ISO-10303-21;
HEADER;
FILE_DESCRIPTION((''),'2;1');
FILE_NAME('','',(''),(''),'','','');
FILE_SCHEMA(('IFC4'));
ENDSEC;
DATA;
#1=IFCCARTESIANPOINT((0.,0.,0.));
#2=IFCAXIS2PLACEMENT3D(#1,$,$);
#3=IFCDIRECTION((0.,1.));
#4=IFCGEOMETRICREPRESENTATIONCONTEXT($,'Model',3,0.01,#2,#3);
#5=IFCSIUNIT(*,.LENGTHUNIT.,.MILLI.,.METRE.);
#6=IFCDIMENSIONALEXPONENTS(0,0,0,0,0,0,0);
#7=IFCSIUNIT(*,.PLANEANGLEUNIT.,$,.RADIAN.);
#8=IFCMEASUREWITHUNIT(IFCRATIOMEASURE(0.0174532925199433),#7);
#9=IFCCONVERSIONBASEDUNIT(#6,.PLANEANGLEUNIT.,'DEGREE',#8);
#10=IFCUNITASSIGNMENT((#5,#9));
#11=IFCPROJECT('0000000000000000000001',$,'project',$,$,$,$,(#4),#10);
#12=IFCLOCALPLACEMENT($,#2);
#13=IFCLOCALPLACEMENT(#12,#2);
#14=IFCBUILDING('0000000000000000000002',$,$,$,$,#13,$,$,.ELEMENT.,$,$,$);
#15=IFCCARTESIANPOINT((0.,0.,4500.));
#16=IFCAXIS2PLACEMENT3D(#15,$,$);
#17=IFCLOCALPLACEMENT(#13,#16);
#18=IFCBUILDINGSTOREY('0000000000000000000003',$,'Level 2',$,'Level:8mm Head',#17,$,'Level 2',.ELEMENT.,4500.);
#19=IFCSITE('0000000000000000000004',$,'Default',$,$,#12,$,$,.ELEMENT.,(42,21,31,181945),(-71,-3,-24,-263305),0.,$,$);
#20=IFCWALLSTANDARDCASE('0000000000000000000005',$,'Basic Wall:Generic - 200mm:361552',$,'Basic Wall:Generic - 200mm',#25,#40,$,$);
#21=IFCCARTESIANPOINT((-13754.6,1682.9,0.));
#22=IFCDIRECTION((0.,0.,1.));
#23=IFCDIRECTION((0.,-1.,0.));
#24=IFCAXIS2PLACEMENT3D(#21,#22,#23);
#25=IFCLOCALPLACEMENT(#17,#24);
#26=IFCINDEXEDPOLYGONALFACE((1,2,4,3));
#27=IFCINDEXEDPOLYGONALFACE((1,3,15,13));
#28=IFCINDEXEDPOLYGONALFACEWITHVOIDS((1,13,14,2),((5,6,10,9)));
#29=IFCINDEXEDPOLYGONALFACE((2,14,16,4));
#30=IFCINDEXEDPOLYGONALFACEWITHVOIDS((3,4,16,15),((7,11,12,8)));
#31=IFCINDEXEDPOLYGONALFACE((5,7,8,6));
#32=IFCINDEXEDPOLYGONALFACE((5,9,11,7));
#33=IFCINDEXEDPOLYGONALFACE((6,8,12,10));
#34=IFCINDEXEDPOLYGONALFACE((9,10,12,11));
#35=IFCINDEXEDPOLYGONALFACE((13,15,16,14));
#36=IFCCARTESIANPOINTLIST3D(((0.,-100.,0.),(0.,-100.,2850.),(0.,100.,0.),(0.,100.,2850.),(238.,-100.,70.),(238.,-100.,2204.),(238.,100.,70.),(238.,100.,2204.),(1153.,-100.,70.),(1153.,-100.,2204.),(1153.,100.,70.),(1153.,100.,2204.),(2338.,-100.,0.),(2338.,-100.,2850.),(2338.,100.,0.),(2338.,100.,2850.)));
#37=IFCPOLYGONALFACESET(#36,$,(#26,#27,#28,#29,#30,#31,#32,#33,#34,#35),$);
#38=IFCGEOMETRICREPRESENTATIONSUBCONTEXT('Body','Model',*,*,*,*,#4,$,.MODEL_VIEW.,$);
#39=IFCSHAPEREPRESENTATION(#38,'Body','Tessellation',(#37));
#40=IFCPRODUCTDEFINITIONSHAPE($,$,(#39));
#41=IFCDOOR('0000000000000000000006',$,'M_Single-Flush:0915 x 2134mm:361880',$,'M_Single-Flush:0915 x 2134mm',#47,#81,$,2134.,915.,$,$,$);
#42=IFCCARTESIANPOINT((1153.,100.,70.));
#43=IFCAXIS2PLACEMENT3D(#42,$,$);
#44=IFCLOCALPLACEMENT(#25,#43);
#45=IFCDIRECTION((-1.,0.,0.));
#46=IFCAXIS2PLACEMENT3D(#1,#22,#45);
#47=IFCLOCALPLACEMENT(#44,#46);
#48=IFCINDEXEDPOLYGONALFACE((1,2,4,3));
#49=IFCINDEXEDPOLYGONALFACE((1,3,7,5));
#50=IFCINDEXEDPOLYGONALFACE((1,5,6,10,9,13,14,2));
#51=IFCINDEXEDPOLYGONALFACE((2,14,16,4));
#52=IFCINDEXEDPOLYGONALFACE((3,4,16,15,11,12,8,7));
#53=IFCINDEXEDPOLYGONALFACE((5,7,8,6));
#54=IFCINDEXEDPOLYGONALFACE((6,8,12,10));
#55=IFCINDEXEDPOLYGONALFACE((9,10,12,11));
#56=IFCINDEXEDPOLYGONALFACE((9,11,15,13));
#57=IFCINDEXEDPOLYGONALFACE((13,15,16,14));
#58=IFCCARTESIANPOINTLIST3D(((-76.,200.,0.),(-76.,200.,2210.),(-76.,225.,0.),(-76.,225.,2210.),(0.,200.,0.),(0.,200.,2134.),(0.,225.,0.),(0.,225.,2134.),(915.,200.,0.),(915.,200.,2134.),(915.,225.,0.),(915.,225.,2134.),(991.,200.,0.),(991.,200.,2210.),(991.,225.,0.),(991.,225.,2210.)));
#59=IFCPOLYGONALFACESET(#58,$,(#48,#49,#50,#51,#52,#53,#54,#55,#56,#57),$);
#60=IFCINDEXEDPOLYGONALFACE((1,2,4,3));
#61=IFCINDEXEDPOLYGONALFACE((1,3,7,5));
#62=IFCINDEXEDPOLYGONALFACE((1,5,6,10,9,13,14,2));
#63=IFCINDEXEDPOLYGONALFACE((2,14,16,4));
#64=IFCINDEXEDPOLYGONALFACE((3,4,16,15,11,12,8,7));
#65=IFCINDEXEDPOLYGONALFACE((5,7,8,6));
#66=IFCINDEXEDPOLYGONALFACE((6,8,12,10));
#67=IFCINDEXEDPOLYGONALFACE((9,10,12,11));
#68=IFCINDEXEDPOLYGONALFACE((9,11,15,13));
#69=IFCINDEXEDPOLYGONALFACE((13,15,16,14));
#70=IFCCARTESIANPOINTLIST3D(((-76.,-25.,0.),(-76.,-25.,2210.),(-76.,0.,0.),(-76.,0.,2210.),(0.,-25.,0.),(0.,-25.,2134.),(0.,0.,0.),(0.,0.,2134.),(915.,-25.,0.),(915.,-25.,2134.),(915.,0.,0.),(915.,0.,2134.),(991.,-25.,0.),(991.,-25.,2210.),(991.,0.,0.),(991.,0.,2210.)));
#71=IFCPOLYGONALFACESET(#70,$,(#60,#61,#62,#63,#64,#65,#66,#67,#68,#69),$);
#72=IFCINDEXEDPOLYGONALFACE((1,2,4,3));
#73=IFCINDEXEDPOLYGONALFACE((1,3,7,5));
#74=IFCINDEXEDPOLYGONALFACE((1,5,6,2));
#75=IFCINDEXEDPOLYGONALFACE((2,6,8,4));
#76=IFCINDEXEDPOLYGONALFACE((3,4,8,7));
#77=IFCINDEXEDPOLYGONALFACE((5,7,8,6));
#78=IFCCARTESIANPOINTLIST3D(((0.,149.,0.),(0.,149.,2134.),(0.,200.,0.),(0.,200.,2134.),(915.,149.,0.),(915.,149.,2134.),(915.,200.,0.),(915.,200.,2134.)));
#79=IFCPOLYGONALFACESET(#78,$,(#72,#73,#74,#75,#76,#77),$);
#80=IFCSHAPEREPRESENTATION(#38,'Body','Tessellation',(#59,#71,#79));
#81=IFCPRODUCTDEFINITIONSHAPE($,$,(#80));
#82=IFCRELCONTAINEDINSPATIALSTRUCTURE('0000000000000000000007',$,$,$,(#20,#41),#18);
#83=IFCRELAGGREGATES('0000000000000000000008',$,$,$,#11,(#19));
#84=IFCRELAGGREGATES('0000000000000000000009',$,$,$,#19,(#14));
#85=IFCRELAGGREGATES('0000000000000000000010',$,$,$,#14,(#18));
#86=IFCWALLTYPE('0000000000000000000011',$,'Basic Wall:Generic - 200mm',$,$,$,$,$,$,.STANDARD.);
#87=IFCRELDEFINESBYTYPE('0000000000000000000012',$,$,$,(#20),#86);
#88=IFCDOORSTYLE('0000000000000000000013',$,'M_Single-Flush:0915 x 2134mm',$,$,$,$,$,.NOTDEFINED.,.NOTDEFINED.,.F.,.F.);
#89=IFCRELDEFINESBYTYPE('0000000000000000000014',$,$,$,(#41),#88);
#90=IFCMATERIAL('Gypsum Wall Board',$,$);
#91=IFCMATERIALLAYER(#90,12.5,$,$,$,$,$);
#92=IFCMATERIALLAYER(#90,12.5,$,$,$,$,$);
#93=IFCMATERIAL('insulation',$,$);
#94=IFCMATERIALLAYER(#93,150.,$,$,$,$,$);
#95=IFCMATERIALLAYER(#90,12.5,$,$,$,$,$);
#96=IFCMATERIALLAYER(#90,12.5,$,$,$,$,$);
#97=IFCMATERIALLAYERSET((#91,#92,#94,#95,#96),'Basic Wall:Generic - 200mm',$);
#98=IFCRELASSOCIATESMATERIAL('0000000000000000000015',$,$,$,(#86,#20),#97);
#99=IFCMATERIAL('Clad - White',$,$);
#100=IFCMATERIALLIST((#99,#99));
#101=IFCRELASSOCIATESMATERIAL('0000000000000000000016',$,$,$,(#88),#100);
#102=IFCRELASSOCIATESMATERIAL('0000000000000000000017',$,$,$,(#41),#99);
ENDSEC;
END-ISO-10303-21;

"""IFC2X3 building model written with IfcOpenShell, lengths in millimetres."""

from ifc_helpers import new_model, entity, si_unit, converted_unit, direction, frame, frame_2d, origin, place, context, subcontext, project, spatial, polyline, rectangle, outline, extrude, source, transform, mapped, material, material_list, layer, layer_set, layer_usage, type_object, type_shapes, element, fill, save


model = new_model("IFC2X3")

# Units and contexts
model_context = context("Model", 3, precision=0.01, world=origin(), true_north=direction((0.0, 1.0)))
body_context = subcontext(model_context, "Body", "Model", "MODEL_VIEW")
ifc_project = project(units=[si_unit("LENGTHUNIT", "METRE", prefix="MILLI"), converted_unit("PLANEANGLEUNIT", "DEGREE", entity("IfcRatioMeasure", 0.0174532925199433), si_unit("PLANEANGLEUNIT", "RADIAN"), dimensions=[0, 0, 0, 0, 0, 0, 0])], contexts=[model_context])

# Site, building, storey
site_placement = place(None, frame((0.0, 0.0, 0.0)))
site = spatial("IfcSite", under=ifc_project, at=site_placement, Name="Default", CompositionType="ELEMENT", RefLatitude=(42, 21, 31, 181945), RefLongitude=(-71, -3, -24, -263305), RefElevation=0.0)
building_placement = place(site_placement, origin())
building = spatial("IfcBuilding", under=site, at=building_placement, CompositionType="ELEMENT")
storey_placement = place(building_placement, frame((0.0, 0.0, 4500.0)))
storey = spatial("IfcBuildingStorey", under=building, at=storey_placement, Name="Level 2", ObjectType="Level:8mm Head", LongName="Level 2", CompositionType="ELEMENT", Elevation=4500.0)

# Wall, opening, door
ifc_material_1 = material(Name="Gypsum Wall Board")
ifc_layer_1 = layer(ifc_material_1, 12.5)
ifc_layer_2 = layer(ifc_material_1, 12.5)
ifc_material_2 = material(Name="insulation")
ifc_layer_3 = layer(ifc_material_2, 150.0)
ifc_layer_4 = layer(ifc_material_1, 12.5)
ifc_layer_5 = layer(ifc_material_1, 12.5)
ifc_layer_set = layer_set([ifc_layer_1, ifc_layer_2, ifc_layer_3, ifc_layer_4, ifc_layer_5], Name="Basic Wall:Generic - 200mm")
ifc_layer_usage_1 = layer_usage(ifc_layer_set, "AXIS2", "NEGATIVE", 100.0)
wall_type = type_object("IfcWallType", Name="Basic Wall:Generic - 200mm", PredefinedType="STANDARD", material=ifc_layer_set)
wall_1_placement = place(storey_placement, frame((-13754.6, 1682.9, 0.0), z_axis=(0.0, 0.0, 1.0), x_axis=(0.0, -1.0, 0.0)))
wall_1 = element("IfcWallStandardCase", 1, at=wall_1_placement, inside=storey, type_object=wall_type, material=ifc_layer_usage_1, Name="Basic Wall:Generic - 200mm:361552", ObjectType="Basic Wall:Generic - 200mm", context=body_context, shape_type="SweptSolid", body=[
    extrude(rectangle(XDim=2338.0, YDim=200.0, at=frame_2d((1169.0, 0.0), x_axis=(-1.0, 0.0))), origin(), (0.0, 0.0, 1.0), 2850.0),
])
opening_placement = place(wall_1_placement, frame((1153.0, 100.0, 70.0)))
opening = element("IfcOpeningElement", 2, at=opening_placement, cuts=wall_1, ObjectType="Opening", context=body_context, shape_type="SweptSolid", body=[
    extrude(rectangle(XDim=915.0, YDim=2134.0, at=frame_2d((1067.0, 457.5), x_axis=(0.0, 1.0))), frame((0.0, 0.0, 0.0), z_axis=(0.0, -1.0, 0.0), x_axis=(0.0, 0.0, 1.0)), (0.0, 0.0, 1.0), 200.0),
])
ifc_material_3 = material(Name="Clad - White")
ifc_material_list = material_list([ifc_material_3, ifc_material_3])
door_style = type_object("IfcDoorStyle", Name="M_Single-Flush:0915 x 2134mm", ConstructionType="NOTDEFINED", OperationType="NOTDEFINED", ParameterTakesPrecedence=False, Sizeable=False, material=ifc_material_list)
shared_shape_1 = source(origin(), body_context, "Body", "SweptSolid", [
    extrude(outline(polyline([(-533.5, -1124.0), (533.5, -1124.0), (533.5, 1086.0), (457.5, 1086.0), (457.5, -1048.0), (-457.5, -1048.0), (-457.5, 1086.0), (-533.5, 1086.0), (-533.5, -1124.0)])), frame((457.5, 200.0, 1086.0), z_axis=(0.0, 1.0, 0.0), x_axis=(1.0, 0.0, 0.0)), (0.0, 0.0, 1.0), 25.0),
    extrude(outline(polyline([(-1124.0, -533.5), (1086.0, -533.5), (1086.0, -457.5), (-1048.0, -457.5), (-1048.0, 457.5), (1086.0, 457.5), (1086.0, 533.5), (-1124.0, 533.5), (-1124.0, -533.5)])), frame((457.5, -25.0, 1086.0), z_axis=(0.0, 1.0, 0.0), x_axis=(0.0, 0.0, -1.0)), (0.0, 0.0, 1.0), 25.0),
    extrude(rectangle(XDim=51.0, YDim=915.0, at=frame_2d((0.0, 0.0), x_axis=(1.0, 0.0))), frame((457.5, 174.5, 0.0), z_axis=(0.0, 0.0, 1.0), x_axis=(0.0, 1.0, 0.0)), (0.0, 0.0, 1.0), 2134.0),
])
type_shapes(door_style, [shared_shape_1])
door_placement = place(opening_placement, frame((0.0, 0.0, 0.0), z_axis=(0.0, 0.0, 1.0), x_axis=(-1.0, 0.0, 0.0)))
door = element("IfcDoor", 3, at=door_placement, inside=storey, type_object=door_style, material=ifc_material_3, Name="M_Single-Flush:0915 x 2134mm:361880", ObjectType="M_Single-Flush:0915 x 2134mm", OverallHeight=2134.0, OverallWidth=915.0, context=body_context, shape_type="MappedRepresentation", body=[
    mapped(shared_shape_1, transform((0.0, 0.0, 0.0), scale=1.0)),
])
fill(opening, door)

save(model, "model.ifc")
